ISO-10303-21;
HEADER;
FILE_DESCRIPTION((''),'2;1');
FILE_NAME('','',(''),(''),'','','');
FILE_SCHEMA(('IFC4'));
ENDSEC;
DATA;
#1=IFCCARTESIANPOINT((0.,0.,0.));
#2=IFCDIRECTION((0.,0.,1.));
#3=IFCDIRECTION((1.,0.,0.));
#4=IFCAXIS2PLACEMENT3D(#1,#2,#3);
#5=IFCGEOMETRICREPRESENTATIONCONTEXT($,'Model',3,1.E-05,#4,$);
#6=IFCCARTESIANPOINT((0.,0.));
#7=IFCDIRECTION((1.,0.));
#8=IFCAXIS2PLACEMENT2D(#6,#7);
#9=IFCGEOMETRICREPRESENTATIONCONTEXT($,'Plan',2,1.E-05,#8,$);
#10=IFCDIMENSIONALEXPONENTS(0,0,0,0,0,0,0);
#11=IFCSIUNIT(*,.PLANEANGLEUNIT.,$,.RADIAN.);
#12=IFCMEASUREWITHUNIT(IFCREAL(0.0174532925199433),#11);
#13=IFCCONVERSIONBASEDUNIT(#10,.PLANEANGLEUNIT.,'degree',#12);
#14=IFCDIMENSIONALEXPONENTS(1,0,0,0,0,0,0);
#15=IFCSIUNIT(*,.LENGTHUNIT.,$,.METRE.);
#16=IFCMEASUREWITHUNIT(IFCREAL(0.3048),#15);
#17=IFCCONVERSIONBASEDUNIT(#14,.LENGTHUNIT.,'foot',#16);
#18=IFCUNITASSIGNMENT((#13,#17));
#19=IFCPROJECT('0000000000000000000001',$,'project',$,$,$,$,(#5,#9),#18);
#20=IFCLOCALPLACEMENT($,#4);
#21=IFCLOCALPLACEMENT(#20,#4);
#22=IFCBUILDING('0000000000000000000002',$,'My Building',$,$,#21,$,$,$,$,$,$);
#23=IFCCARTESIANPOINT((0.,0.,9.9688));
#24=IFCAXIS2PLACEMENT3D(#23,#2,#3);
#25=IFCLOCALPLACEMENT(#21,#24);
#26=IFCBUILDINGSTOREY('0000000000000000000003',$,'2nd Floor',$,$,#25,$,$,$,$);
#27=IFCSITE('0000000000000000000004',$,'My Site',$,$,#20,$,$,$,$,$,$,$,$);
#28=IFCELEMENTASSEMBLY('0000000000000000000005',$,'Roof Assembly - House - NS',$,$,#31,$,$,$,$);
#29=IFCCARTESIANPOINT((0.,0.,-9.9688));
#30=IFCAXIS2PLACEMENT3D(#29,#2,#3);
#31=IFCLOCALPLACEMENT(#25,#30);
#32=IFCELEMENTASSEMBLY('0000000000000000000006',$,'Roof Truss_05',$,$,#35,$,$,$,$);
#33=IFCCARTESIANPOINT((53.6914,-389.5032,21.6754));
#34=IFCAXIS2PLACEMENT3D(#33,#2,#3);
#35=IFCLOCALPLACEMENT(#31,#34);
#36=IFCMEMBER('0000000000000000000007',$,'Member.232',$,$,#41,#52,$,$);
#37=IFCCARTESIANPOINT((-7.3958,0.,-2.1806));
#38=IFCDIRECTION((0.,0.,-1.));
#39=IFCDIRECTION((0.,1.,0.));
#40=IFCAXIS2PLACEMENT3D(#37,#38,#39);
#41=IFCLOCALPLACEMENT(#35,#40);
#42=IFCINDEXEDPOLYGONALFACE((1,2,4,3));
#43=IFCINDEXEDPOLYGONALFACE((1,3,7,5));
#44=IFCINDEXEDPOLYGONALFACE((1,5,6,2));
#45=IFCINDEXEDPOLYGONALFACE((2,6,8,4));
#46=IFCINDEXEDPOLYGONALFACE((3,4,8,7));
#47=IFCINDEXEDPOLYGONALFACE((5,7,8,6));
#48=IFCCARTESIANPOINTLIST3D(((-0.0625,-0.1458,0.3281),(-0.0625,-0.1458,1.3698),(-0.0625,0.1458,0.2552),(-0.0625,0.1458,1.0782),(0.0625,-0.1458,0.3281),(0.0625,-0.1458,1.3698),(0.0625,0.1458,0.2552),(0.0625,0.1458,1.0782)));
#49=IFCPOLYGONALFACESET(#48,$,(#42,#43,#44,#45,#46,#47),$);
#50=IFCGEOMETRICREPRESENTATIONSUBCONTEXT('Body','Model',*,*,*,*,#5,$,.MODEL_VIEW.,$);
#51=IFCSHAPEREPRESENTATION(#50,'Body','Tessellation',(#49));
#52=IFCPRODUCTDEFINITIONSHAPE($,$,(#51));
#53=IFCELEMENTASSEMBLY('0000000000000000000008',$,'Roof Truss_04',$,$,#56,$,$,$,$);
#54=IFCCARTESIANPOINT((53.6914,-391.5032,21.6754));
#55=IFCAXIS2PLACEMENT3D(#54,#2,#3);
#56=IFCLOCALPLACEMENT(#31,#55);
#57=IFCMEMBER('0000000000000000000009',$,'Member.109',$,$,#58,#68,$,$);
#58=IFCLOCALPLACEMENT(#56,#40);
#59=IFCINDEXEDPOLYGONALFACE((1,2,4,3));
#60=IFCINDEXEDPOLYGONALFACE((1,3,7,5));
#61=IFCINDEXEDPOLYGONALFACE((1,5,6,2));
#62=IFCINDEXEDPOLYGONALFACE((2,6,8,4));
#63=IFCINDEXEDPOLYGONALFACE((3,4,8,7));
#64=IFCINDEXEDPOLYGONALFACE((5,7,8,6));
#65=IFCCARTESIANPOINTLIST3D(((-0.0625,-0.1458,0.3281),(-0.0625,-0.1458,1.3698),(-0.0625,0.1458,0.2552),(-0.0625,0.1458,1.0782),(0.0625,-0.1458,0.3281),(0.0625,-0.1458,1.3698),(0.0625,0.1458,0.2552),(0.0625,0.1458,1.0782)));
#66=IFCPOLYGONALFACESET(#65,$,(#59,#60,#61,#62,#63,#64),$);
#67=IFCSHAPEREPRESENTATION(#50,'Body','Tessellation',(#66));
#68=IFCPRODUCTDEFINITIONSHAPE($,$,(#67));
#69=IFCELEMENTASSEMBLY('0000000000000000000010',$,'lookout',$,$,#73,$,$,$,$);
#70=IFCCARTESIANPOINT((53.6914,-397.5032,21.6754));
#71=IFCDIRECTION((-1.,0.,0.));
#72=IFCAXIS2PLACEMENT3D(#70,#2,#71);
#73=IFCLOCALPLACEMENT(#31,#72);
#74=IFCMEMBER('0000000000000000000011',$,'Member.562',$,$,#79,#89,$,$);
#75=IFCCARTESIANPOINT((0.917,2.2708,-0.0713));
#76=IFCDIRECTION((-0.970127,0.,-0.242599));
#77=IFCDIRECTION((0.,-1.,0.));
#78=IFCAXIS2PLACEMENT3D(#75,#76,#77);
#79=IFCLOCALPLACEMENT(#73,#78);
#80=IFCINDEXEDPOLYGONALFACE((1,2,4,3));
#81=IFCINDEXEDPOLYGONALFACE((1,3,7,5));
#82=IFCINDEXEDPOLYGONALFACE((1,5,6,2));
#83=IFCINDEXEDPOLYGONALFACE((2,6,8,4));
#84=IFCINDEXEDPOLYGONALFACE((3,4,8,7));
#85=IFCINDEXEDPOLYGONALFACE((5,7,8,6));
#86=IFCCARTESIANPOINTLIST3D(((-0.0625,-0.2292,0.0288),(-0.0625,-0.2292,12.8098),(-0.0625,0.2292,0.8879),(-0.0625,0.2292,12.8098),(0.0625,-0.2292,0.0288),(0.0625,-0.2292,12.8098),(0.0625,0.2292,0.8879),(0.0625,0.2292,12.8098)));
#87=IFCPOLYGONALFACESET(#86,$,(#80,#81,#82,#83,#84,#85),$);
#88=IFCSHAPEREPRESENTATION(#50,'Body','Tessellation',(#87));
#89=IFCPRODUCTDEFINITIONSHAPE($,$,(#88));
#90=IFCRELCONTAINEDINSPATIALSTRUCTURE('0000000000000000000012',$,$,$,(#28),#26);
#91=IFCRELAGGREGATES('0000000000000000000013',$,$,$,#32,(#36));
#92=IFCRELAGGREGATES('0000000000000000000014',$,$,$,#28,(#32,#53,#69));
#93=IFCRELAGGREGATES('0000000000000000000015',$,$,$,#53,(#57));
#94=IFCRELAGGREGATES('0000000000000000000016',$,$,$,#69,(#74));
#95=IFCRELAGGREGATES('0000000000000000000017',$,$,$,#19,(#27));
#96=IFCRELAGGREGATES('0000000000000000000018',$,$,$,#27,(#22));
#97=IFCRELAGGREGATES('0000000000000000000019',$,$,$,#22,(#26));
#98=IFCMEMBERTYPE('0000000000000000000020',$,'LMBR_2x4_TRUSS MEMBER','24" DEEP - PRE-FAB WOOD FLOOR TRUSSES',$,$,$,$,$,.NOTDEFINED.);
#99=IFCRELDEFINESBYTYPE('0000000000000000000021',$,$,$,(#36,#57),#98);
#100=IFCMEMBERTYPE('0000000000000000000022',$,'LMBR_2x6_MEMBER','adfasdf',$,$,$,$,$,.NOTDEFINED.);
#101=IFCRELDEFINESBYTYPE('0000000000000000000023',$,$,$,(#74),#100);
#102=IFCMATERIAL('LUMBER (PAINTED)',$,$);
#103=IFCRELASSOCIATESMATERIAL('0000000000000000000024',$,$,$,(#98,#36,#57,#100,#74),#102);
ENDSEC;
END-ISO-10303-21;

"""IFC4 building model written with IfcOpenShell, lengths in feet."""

from ifc_helpers import new_model, entity, si_unit, converted_unit, frame, origin_with_axes, origin_2d_with_axis, place, context, subcontext, project, spatial, indexed_curve, outline, extrude, clip, halfspace, material, material_profile, profile_set, profile_usage, type_object, element, aggregate, save


model = new_model("IFC4")

# Units and contexts
model_context = context("Model", 3, precision=1e-05, world=origin_with_axes())
plan_context = context("Plan", 2, precision=1e-05, world=origin_2d_with_axis())
body_context = subcontext(model_context, "Body", "Model", "MODEL_VIEW")
ifc_project = project(units=[converted_unit("PLANEANGLEUNIT", "degree", entity("IfcReal", 0.0174532925199433), si_unit("PLANEANGLEUNIT", "RADIAN"), dimensions=[0, 0, 0, 0, 0, 0, 0]), converted_unit("LENGTHUNIT", "foot", entity("IfcReal", 0.3048), si_unit("LENGTHUNIT", "METRE"), dimensions=[1, 0, 0, 0, 0, 0, 0])], contexts=[model_context, plan_context])

# Site, building, storey
site_placement = place(None, origin_with_axes())
site = spatial("IfcSite", under=ifc_project, at=site_placement, Name="My Site")
building_placement = place(site_placement, origin_with_axes())
building = spatial("IfcBuilding", under=site, at=building_placement, Name="My Building")
storey_placement = place(building_placement, frame((0.0, 0.0, 9.9688), z_axis=(0.0, 0.0, 1.0), x_axis=(1.0, 0.0, 0.0)))
storey = spatial("IfcBuildingStorey", under=building, at=storey_placement, Name="2nd Floor")

# Element assemblies, members
assembly_1_placement = place(storey_placement, frame((0.0, 0.0, -9.9688), z_axis=(0.0, 0.0, 1.0), x_axis=(1.0, 0.0, 0.0)))
assembly_1 = element("IfcElementAssembly", 1, at=assembly_1_placement, inside=storey, Name="Roof Assembly - House - NS")
ifc_material = material(Name="LUMBER (PAINTED)")
ifc_material_profile_1 = material_profile(ifc_material, outline(indexed_curve([(-0.0625, -0.1458), (0.0625, -0.1458), (0.0625, 0.1458), (-0.0625, 0.1458), (-0.0625, -0.1458)])))
ifc_profile_set_1 = profile_set([ifc_material_profile_1])
member_type_1 = type_object("IfcMemberType", Name="LMBR_2x4_TRUSS MEMBER", Description="24\" DEEP - PRE-FAB WOOD FLOOR TRUSSES", PredefinedType="NOTDEFINED", material=ifc_profile_set_1)
assembly_2_placement = place(assembly_1_placement, frame((53.6914, -389.5032, 21.6754), z_axis=(0.0, 0.0, 1.0), x_axis=(1.0, 0.0, 0.0)))
assembly_2 = element("IfcElementAssembly", 2, at=assembly_2_placement, Name="Roof Truss_05")
ifc_profile_usage_1 = profile_usage(ifc_profile_set_1)
member_1_placement = place(assembly_2_placement, frame((-7.3958, 0.0, -2.1806), z_axis=(0.0, 0.0, -1.0), x_axis=(0.0, 1.0, 0.0)))
member_1 = element("IfcMember", 3, at=member_1_placement, type_object=member_type_1, material=ifc_profile_usage_1, Name="Member.232", context=body_context, shape_type="Clipping", body=[
    clip(clip(extrude(outline(indexed_curve([(-0.0625, -0.1458), (0.0625, -0.1458), (0.0625, 0.1458), (-0.0625, 0.1458), (-0.0625, -0.1458)])), origin_with_axes(), (0.0, 0.0, 1.0), 1.3698), halfspace(frame((0.0, 7.5424, -1.5944), z_axis=(0.0, -0.242599, -0.970127), x_axis=(-1.0, 0.000001, 0.0)), False)), halfspace(frame((397.5032, -0.1458, 1.3698), z_axis=(0.0, 0.707107, 0.707107), x_axis=(1.0, 0.0, 0.0)), False)),
])
aggregate(assembly_2, [member_1])
assembly_3_placement = place(assembly_1_placement, frame((53.6914, -391.5032, 21.6754), z_axis=(0.0, 0.0, 1.0), x_axis=(1.0, 0.0, 0.0)))
assembly_3 = element("IfcElementAssembly", 4, at=assembly_3_placement, Name="Roof Truss_04")
ifc_profile_usage_2 = profile_usage(ifc_profile_set_1)
member_2_placement = place(assembly_3_placement, frame((-7.3958, 0.0, -2.1806), z_axis=(0.0, 0.0, -1.0), x_axis=(0.0, 1.0, 0.0)))
member_2 = element("IfcMember", 5, at=member_2_placement, type_object=member_type_1, material=ifc_profile_usage_2, Name="Member.109", context=body_context, shape_type="Clipping", body=[
    clip(clip(extrude(outline(indexed_curve([(-0.0625, -0.1458), (0.0625, -0.1458), (0.0625, 0.1458), (-0.0625, 0.1458), (-0.0625, -0.1458)])), origin_with_axes(), (0.0, 0.0, 1.0), 1.3698), halfspace(frame((0.0, 7.5424, -1.5944), z_axis=(0.0, -0.242599, -0.970127), x_axis=(-1.0, 0.000001, 0.0)), False)), halfspace(frame((397.5032, -0.1458, 1.3698), z_axis=(0.0, 0.707107, 0.707107), x_axis=(1.0, 0.0, 0.0)), False)),
])
assembly_4_placement = place(assembly_1_placement, frame((53.6914, -397.5032, 21.6754), z_axis=(0.0, 0.0, 1.0), x_axis=(-1.0, 0.0, 0.0)))
assembly_4 = element("IfcElementAssembly", 6, at=assembly_4_placement, Name="lookout")
aggregate(assembly_1, [assembly_2, assembly_3, assembly_4])
ifc_material_profile_2 = material_profile(ifc_material, outline(indexed_curve([(-0.0625, 0.2292), (0.0625, 0.2292), (0.0625, -0.2292), (-0.0625, -0.2292), (-0.0625, 0.2292)])))
ifc_profile_set_2 = profile_set([ifc_material_profile_2])
ifc_profile_usage_3 = profile_usage(ifc_profile_set_2)
member_type_2 = type_object("IfcMemberType", Name="LMBR_2x6_MEMBER", Description="adfasdf", PredefinedType="NOTDEFINED", material=ifc_profile_set_2)
member_3_placement = place(assembly_4_placement, frame((0.917, 2.2708, -0.0713), z_axis=(-0.970127, 0.0, -0.242599), x_axis=(0.0, -1.0, 0.0)))
member_3 = element("IfcMember", 7, at=member_3_placement, type_object=member_type_2, material=ifc_profile_usage_3, Name="Member.562", context=body_context, shape_type="Clipping", body=[
    clip(extrude(outline(indexed_curve([(-0.0625, 0.2292), (0.0625, 0.2292), (0.0625, -0.2292), (-0.0625, -0.2292), (-0.0625, 0.2292)])), origin_with_axes(), (0.0, 0.0, 1.0), 12.8098), halfspace(frame((0.0, 0.1888, 0.8122), z_axis=(0.0, 0.882291, -0.470704), x_axis=(1.0, 0.0, 0.0)), False)),
])
aggregate(assembly_3, [member_2])
aggregate(assembly_4, [member_3])

save(model, "model.ifc")
